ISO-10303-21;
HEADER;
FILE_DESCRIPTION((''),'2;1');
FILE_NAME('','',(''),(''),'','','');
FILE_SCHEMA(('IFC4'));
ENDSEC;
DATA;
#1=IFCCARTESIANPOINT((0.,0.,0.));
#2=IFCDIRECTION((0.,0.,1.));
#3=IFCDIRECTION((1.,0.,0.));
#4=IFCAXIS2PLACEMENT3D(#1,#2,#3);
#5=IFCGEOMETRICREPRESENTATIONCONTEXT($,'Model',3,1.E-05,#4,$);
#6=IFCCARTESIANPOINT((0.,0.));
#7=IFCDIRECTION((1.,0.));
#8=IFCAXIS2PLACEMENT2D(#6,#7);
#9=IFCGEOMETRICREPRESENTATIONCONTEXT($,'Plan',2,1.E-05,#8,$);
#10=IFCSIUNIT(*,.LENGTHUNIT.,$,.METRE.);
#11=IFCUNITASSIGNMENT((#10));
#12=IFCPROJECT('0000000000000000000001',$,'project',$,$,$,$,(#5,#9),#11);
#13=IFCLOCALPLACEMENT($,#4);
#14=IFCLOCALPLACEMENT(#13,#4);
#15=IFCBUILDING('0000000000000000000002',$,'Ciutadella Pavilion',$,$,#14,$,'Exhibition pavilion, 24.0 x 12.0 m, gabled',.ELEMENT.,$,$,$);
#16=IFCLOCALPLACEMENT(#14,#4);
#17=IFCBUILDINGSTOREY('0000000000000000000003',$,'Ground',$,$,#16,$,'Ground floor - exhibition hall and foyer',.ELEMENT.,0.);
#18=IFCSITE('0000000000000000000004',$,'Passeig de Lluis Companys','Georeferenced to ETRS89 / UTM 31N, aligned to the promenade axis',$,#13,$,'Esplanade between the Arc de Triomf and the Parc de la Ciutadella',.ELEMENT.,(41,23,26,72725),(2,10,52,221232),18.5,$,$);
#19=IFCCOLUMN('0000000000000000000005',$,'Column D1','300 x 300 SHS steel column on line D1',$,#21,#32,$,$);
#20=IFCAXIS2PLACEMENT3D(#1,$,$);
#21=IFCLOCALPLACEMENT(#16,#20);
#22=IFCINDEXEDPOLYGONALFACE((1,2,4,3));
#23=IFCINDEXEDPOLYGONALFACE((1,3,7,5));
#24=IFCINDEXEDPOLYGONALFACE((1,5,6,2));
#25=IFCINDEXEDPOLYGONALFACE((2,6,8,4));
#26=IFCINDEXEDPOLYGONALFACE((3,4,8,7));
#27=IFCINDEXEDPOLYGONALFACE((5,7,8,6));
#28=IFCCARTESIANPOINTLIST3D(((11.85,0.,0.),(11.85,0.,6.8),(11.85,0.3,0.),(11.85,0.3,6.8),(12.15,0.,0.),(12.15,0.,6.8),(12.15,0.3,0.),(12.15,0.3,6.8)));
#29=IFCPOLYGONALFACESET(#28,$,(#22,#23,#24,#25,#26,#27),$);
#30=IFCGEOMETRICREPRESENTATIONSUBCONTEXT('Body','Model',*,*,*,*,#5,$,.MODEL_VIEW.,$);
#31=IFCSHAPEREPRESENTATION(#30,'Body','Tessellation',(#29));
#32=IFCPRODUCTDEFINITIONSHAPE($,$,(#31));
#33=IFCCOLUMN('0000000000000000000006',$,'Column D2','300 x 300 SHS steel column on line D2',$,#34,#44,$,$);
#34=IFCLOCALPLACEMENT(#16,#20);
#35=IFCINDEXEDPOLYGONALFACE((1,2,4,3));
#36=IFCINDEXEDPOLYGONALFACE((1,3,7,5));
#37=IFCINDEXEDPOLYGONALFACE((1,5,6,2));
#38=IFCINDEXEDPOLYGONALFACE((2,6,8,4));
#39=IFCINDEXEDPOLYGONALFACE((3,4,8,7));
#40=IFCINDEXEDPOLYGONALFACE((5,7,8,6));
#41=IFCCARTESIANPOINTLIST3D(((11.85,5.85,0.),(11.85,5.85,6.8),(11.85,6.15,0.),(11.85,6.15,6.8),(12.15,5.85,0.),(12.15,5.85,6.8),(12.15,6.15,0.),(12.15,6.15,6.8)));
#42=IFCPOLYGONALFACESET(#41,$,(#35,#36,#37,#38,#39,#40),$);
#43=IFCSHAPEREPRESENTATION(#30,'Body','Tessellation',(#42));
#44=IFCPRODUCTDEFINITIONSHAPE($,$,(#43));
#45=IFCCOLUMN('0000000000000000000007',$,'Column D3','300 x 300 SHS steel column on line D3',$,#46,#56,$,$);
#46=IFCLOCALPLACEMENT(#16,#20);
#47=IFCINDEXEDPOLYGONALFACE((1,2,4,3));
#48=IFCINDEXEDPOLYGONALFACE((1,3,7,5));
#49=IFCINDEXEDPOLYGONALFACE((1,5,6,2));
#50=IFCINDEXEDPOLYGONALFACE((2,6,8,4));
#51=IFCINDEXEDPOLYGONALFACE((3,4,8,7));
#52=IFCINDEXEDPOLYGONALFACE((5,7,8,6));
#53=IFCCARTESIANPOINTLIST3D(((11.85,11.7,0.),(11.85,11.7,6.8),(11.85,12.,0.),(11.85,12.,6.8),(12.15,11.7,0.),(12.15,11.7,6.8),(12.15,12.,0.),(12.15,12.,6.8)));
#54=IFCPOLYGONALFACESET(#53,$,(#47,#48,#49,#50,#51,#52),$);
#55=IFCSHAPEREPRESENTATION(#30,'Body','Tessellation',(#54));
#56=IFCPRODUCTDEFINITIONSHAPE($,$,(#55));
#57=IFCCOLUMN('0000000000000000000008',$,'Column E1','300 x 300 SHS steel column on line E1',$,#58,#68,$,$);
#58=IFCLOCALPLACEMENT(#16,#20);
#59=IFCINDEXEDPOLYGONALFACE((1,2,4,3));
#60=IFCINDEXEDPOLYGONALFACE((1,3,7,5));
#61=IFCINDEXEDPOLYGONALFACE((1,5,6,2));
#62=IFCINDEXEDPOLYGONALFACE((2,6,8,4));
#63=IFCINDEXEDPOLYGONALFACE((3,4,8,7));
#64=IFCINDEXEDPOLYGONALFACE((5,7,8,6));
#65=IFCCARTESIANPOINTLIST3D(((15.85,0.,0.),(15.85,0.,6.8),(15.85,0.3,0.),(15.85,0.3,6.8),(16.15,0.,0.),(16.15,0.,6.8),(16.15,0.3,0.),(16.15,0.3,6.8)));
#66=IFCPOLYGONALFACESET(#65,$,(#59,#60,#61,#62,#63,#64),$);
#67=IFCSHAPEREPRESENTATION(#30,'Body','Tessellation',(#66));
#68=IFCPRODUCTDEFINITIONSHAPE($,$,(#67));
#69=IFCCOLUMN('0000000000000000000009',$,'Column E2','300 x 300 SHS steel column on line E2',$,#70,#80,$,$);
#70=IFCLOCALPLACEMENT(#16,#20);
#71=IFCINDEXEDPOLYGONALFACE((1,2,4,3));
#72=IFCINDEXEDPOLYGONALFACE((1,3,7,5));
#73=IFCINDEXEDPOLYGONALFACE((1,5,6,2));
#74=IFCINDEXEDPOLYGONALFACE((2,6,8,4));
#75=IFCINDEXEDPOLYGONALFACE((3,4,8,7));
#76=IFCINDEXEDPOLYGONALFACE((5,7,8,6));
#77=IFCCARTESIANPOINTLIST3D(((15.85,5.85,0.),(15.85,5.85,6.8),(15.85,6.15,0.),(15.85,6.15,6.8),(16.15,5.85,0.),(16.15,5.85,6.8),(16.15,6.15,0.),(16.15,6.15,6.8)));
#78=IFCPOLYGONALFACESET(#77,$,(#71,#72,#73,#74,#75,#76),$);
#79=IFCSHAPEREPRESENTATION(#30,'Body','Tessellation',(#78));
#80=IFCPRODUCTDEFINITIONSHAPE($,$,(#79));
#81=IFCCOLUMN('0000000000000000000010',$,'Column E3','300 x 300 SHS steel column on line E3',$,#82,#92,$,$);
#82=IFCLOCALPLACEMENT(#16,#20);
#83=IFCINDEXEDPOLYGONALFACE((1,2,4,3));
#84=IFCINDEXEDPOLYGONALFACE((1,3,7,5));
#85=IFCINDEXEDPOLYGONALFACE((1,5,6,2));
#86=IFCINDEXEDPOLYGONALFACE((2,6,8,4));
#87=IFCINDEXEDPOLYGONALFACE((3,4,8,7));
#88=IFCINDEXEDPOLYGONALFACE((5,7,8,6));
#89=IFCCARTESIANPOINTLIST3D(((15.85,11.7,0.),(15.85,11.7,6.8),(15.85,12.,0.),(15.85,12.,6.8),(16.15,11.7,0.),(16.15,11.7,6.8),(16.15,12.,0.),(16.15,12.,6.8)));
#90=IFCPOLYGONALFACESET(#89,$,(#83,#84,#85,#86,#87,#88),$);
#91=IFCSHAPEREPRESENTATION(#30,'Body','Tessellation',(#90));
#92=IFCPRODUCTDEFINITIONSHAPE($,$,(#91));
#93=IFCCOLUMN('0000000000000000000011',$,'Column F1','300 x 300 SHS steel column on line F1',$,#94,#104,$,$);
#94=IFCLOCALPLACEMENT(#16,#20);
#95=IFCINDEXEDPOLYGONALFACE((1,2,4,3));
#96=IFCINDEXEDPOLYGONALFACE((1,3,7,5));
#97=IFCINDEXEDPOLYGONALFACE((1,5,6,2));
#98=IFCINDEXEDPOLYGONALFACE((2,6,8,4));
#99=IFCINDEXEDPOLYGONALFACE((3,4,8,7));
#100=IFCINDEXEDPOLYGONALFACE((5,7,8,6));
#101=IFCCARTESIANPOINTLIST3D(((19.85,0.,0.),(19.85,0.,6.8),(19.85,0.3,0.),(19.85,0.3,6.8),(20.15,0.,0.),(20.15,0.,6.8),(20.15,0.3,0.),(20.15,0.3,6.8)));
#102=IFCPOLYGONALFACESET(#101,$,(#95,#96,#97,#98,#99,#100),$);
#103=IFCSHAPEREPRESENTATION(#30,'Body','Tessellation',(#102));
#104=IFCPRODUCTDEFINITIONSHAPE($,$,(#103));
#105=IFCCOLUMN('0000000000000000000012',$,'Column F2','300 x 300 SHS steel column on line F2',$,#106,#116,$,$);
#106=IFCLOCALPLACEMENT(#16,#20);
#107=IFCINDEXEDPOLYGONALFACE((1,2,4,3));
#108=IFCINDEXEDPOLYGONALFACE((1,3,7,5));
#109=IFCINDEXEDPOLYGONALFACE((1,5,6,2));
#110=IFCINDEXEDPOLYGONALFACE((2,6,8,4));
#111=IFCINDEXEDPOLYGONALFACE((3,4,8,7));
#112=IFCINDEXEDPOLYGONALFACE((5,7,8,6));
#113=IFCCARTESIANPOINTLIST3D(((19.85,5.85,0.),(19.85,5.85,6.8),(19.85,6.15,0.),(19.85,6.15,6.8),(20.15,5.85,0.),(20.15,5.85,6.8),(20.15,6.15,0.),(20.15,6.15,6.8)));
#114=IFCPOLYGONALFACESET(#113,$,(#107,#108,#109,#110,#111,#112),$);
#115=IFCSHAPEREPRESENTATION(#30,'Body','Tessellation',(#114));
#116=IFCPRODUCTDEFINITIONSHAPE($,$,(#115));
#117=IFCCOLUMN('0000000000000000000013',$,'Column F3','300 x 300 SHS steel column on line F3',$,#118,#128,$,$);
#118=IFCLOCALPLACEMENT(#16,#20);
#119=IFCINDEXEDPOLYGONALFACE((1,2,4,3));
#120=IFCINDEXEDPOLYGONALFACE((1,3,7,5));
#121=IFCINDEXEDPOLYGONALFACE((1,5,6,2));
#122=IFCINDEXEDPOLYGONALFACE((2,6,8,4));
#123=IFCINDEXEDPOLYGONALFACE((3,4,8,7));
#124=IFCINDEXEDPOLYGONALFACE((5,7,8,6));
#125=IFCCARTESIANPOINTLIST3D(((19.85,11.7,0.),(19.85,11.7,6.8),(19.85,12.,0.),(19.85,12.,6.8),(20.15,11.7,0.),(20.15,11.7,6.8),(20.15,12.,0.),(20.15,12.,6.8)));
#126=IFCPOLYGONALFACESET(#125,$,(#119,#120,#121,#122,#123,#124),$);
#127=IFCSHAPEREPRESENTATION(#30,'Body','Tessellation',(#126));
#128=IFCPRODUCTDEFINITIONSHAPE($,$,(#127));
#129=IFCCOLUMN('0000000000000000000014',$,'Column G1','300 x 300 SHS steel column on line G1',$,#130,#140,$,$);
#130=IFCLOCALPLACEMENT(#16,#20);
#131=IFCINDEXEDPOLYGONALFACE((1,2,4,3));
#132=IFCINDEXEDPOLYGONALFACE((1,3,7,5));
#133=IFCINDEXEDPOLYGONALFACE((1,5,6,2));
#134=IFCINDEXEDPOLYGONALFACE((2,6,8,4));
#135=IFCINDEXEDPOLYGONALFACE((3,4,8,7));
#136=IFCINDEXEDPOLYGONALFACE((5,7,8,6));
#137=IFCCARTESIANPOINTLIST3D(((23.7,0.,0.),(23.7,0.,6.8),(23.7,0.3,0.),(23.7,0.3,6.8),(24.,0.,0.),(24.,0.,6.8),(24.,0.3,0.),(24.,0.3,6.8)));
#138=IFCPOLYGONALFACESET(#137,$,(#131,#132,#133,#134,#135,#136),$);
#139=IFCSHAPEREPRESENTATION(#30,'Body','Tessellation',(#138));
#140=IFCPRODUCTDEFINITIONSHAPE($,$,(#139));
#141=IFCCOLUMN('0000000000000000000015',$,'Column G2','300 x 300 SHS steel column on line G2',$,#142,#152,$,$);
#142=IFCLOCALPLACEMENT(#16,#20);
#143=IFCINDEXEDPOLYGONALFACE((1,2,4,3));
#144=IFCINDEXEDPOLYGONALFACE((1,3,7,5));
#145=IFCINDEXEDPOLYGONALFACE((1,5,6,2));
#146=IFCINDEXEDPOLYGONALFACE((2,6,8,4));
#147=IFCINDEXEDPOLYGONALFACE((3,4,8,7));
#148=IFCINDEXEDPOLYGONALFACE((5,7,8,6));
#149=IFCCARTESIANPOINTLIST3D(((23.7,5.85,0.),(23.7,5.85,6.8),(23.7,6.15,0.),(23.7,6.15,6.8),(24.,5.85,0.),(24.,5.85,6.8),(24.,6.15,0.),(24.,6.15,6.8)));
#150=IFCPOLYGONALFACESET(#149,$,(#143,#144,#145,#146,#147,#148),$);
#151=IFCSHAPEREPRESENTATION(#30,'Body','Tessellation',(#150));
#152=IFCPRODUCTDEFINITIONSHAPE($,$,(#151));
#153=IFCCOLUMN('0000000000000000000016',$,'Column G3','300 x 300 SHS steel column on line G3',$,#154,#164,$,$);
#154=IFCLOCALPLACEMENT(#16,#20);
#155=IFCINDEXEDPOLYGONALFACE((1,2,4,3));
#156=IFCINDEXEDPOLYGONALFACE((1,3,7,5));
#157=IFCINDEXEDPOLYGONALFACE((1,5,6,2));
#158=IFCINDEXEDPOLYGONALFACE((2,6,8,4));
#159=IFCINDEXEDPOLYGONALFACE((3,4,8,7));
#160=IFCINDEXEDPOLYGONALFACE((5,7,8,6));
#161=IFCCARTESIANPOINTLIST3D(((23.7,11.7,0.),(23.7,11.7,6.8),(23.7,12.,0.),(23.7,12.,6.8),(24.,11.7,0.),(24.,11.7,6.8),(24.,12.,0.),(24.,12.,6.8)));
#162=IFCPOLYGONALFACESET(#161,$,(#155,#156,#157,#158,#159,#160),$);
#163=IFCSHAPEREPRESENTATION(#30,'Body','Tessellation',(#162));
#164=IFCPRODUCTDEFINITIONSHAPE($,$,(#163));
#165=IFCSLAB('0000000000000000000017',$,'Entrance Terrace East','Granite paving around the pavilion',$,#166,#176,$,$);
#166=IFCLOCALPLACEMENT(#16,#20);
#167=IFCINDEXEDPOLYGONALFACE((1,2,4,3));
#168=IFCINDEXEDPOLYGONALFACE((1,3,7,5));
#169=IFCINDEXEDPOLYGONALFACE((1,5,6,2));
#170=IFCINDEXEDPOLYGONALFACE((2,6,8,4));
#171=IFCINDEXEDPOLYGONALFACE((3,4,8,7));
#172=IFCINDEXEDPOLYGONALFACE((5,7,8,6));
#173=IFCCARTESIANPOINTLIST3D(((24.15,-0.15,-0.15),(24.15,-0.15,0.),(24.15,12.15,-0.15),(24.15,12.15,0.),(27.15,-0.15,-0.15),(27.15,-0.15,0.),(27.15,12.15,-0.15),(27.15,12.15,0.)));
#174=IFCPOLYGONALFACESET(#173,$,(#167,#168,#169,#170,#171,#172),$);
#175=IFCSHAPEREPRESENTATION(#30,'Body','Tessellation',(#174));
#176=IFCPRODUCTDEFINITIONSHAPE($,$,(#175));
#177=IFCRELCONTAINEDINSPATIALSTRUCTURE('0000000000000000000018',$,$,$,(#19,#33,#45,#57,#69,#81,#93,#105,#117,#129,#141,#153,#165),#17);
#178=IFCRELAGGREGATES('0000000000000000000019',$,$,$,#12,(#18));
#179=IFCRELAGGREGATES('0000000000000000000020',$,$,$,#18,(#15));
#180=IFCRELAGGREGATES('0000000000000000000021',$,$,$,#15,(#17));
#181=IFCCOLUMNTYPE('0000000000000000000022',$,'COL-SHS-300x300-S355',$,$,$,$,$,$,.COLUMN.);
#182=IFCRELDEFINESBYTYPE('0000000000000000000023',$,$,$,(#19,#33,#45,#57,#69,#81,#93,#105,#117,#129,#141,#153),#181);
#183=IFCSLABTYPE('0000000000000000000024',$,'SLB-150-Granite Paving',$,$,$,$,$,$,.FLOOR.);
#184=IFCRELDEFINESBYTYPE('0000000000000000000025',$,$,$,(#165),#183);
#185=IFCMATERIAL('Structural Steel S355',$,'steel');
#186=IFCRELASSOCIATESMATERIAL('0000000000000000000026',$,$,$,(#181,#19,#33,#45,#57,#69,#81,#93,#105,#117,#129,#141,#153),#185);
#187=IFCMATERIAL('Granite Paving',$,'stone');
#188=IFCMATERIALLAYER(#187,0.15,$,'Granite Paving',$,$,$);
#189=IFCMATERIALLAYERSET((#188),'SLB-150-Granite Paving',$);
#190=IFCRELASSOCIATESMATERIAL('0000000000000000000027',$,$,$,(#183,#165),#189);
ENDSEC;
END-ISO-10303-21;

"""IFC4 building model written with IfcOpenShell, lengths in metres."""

from ifc_helpers import new_model, si_unit, frame, origin_with_axes, origin_2d_with_axis, place, context, subcontext, project, spatial, line, indexed_curve, rectangle, outline, extrude, material, layer, layer_set, layer_usage, material_profile, profile_set, profile_usage, type_object, element, save


model = new_model("IFC4")

# Units and contexts
model_context = context("Model", 3, precision=1e-05, world=origin_with_axes())
plan_context = context("Plan", 2, precision=1e-05, world=origin_2d_with_axis())
body_context = subcontext(model_context, "Body", "Model", "MODEL_VIEW")
ifc_project = project(units=[si_unit("LENGTHUNIT", "METRE")], contexts=[model_context, plan_context])

# Site, building, storey
site_placement = place(None, origin_with_axes())
site = spatial("IfcSite", under=ifc_project, at=site_placement, Name="Passeig de Lluis Companys", Description="Georeferenced to ETRS89 / UTM 31N, aligned to the promenade axis", LongName="Esplanade between the Arc de Triomf and the Parc de la Ciutadella", CompositionType="ELEMENT", RefLatitude=(41, 23, 26, 72725), RefLongitude=(2, 10, 52, 221232), RefElevation=18.5)
building_placement = place(site_placement, origin_with_axes())
building = spatial("IfcBuilding", under=site, at=building_placement, Name="Ciutadella Pavilion", LongName="Exhibition pavilion, 24.0 x 12.0 m, gabled", CompositionType="ELEMENT")
storey_placement = place(building_placement, origin_with_axes())
storey = spatial("IfcBuildingStorey", under=building, at=storey_placement, Name="Ground", LongName="Ground floor - exhibition hall and foyer", CompositionType="ELEMENT", Elevation=0.0)

# Columns
ifc_material_1 = material(Name="Structural Steel S355", Category="steel")
ifc_material_profile = material_profile(ifc_material_1, rectangle(XDim=0.3, YDim=0.3))
ifc_profile_set = profile_set([ifc_material_profile], Name="COL-SHS-300x300-S355")
ifc_profile_usage_1 = profile_usage(ifc_profile_set)
column_type = type_object("IfcColumnType", Name="COL-SHS-300x300-S355", PredefinedType="COLUMN", material=ifc_profile_set)
column_1_placement = place(storey_placement, frame((11.85, 0.0, 0.0), z_axis=(0.0, 0.0, 1.0), x_axis=(1.0, 0.0, 0.0)))
element("IfcColumn", 1, at=column_1_placement, inside=storey, type_object=column_type, material=ifc_profile_usage_1, Name="Column D1", Description="300 x 300 SHS steel column on line D1", context=body_context, shape_type="SweptSolid", body=[
    extrude(outline(indexed_curve([(0.0, 0.0), (0.3, 0.0), (0.3, 0.3), (0.0, 0.3)], segments=[line(1, 2, 3, 4, 1)])), origin_with_axes(), (0.0, 0.0, 1.0), 6.8),
])
ifc_profile_usage_2 = profile_usage(ifc_profile_set)
column_2_placement = place(storey_placement, frame((11.85, 5.85, 0.0), z_axis=(0.0, 0.0, 1.0), x_axis=(1.0, 0.0, 0.0)))
element("IfcColumn", 2, at=column_2_placement, inside=storey, type_object=column_type, material=ifc_profile_usage_2, Name="Column D2", Description="300 x 300 SHS steel column on line D2", context=body_context, shape_type="SweptSolid", body=[
    extrude(outline(indexed_curve([(0.0, 0.0), (0.3, 0.0), (0.3, 0.3), (0.0, 0.3)], segments=[line(1, 2, 3, 4, 1)])), origin_with_axes(), (0.0, 0.0, 1.0), 6.8),
])
ifc_profile_usage_3 = profile_usage(ifc_profile_set)
column_3_placement = place(storey_placement, frame((11.85, 11.7, 0.0), z_axis=(0.0, 0.0, 1.0), x_axis=(1.0, 0.0, 0.0)))
element("IfcColumn", 3, at=column_3_placement, inside=storey, type_object=column_type, material=ifc_profile_usage_3, Name="Column D3", Description="300 x 300 SHS steel column on line D3", context=body_context, shape_type="SweptSolid", body=[
    extrude(outline(indexed_curve([(0.0, 0.0), (0.3, 0.0), (0.3, 0.3), (0.0, 0.3)], segments=[line(1, 2, 3, 4, 1)])), origin_with_axes(), (0.0, 0.0, 1.0), 6.8),
])
ifc_profile_usage_4 = profile_usage(ifc_profile_set)
column_4_placement = place(storey_placement, frame((15.85, 0.0, 0.0), z_axis=(0.0, 0.0, 1.0), x_axis=(1.0, 0.0, 0.0)))
element("IfcColumn", 4, at=column_4_placement, inside=storey, type_object=column_type, material=ifc_profile_usage_4, Name="Column E1", Description="300 x 300 SHS steel column on line E1", context=body_context, shape_type="SweptSolid", body=[
    extrude(outline(indexed_curve([(0.0, 0.0), (0.3, 0.0), (0.3, 0.3), (0.0, 0.3)], segments=[line(1, 2, 3, 4, 1)])), origin_with_axes(), (0.0, 0.0, 1.0), 6.8),
])
ifc_profile_usage_5 = profile_usage(ifc_profile_set)
column_5_placement = place(storey_placement, frame((15.85, 5.85, 0.0), z_axis=(0.0, 0.0, 1.0), x_axis=(1.0, 0.0, 0.0)))
element("IfcColumn", 5, at=column_5_placement, inside=storey, type_object=column_type, material=ifc_profile_usage_5, Name="Column E2", Description="300 x 300 SHS steel column on line E2", context=body_context, shape_type="SweptSolid", body=[
    extrude(outline(indexed_curve([(0.0, 0.0), (0.3, 0.0), (0.3, 0.3), (0.0, 0.3)], segments=[line(1, 2, 3, 4, 1)])), origin_with_axes(), (0.0, 0.0, 1.0), 6.8),
])
ifc_profile_usage_6 = profile_usage(ifc_profile_set)
column_6_placement = place(storey_placement, frame((15.85, 11.7, 0.0), z_axis=(0.0, 0.0, 1.0), x_axis=(1.0, 0.0, 0.0)))
element("IfcColumn", 6, at=column_6_placement, inside=storey, type_object=column_type, material=ifc_profile_usage_6, Name="Column E3", Description="300 x 300 SHS steel column on line E3", context=body_context, shape_type="SweptSolid", body=[
    extrude(outline(indexed_curve([(0.0, 0.0), (0.3, 0.0), (0.3, 0.3), (0.0, 0.3)], segments=[line(1, 2, 3, 4, 1)])), origin_with_axes(), (0.0, 0.0, 1.0), 6.8),
])
ifc_profile_usage_7 = profile_usage(ifc_profile_set)
column_7_placement = place(storey_placement, frame((19.85, 0.0, 0.0), z_axis=(0.0, 0.0, 1.0), x_axis=(1.0, 0.0, 0.0)))
element("IfcColumn", 7, at=column_7_placement, inside=storey, type_object=column_type, material=ifc_profile_usage_7, Name="Column F1", Description="300 x 300 SHS steel column on line F1", context=body_context, shape_type="SweptSolid", body=[
    extrude(outline(indexed_curve([(0.0, 0.0), (0.3, 0.0), (0.3, 0.3), (0.0, 0.3)], segments=[line(1, 2, 3, 4, 1)])), origin_with_axes(), (0.0, 0.0, 1.0), 6.8),
])
ifc_profile_usage_8 = profile_usage(ifc_profile_set)
column_8_placement = place(storey_placement, frame((19.85, 5.85, 0.0), z_axis=(0.0, 0.0, 1.0), x_axis=(1.0, 0.0, 0.0)))
element("IfcColumn", 8, at=column_8_placement, inside=storey, type_object=column_type, material=ifc_profile_usage_8, Name="Column F2", Description="300 x 300 SHS steel column on line F2", context=body_context, shape_type="SweptSolid", body=[
    extrude(outline(indexed_curve([(0.0, 0.0), (0.3, 0.0), (0.3, 0.3), (0.0, 0.3)], segments=[line(1, 2, 3, 4, 1)])), origin_with_axes(), (0.0, 0.0, 1.0), 6.8),
])
ifc_profile_usage_9 = profile_usage(ifc_profile_set)
column_9_placement = place(storey_placement, frame((19.85, 11.7, 0.0), z_axis=(0.0, 0.0, 1.0), x_axis=(1.0, 0.0, 0.0)))
element("IfcColumn", 9, at=column_9_placement, inside=storey, type_object=column_type, material=ifc_profile_usage_9, Name="Column F3", Description="300 x 300 SHS steel column on line F3", context=body_context, shape_type="SweptSolid", body=[
    extrude(outline(indexed_curve([(0.0, 0.0), (0.3, 0.0), (0.3, 0.3), (0.0, 0.3)], segments=[line(1, 2, 3, 4, 1)])), origin_with_axes(), (0.0, 0.0, 1.0), 6.8),
])
ifc_profile_usage_10 = profile_usage(ifc_profile_set)
column_10_placement = place(storey_placement, frame((23.7, 0.0, 0.0), z_axis=(0.0, 0.0, 1.0), x_axis=(1.0, 0.0, 0.0)))
element("IfcColumn", 10, at=column_10_placement, inside=storey, type_object=column_type, material=ifc_profile_usage_10, Name="Column G1", Description="300 x 300 SHS steel column on line G1", context=body_context, shape_type="SweptSolid", body=[
    extrude(outline(indexed_curve([(0.0, 0.0), (0.3, 0.0), (0.3, 0.3), (0.0, 0.3)], segments=[line(1, 2, 3, 4, 1)])), origin_with_axes(), (0.0, 0.0, 1.0), 6.8),
])
ifc_profile_usage_11 = profile_usage(ifc_profile_set)
column_11_placement = place(storey_placement, frame((23.7, 5.85, 0.0), z_axis=(0.0, 0.0, 1.0), x_axis=(1.0, 0.0, 0.0)))
element("IfcColumn", 11, at=column_11_placement, inside=storey, type_object=column_type, material=ifc_profile_usage_11, Name="Column G2", Description="300 x 300 SHS steel column on line G2", context=body_context, shape_type="SweptSolid", body=[
    extrude(outline(indexed_curve([(0.0, 0.0), (0.3, 0.0), (0.3, 0.3), (0.0, 0.3)], segments=[line(1, 2, 3, 4, 1)])), origin_with_axes(), (0.0, 0.0, 1.0), 6.8),
])
ifc_profile_usage_12 = profile_usage(ifc_profile_set)
column_12_placement = place(storey_placement, frame((23.7, 11.7, 0.0), z_axis=(0.0, 0.0, 1.0), x_axis=(1.0, 0.0, 0.0)))
element("IfcColumn", 12, at=column_12_placement, inside=storey, type_object=column_type, material=ifc_profile_usage_12, Name="Column G3", Description="300 x 300 SHS steel column on line G3", context=body_context, shape_type="SweptSolid", body=[
    extrude(outline(indexed_curve([(0.0, 0.0), (0.3, 0.0), (0.3, 0.3), (0.0, 0.3)], segments=[line(1, 2, 3, 4, 1)])), origin_with_axes(), (0.0, 0.0, 1.0), 6.8),
])

# Slab
ifc_material_2 = material(Name="Granite Paving", Category="stone")
ifc_layer_1 = layer(ifc_material_2, 0.15, Name="Granite Paving")
ifc_layer_set_1 = layer_set([ifc_layer_1], Name="SLB-150-Granite Paving")
ifc_layer_usage_1 = layer_usage(ifc_layer_set_1, "AXIS3", "POSITIVE", 0.0)
slab_type = type_object("IfcSlabType", Name="SLB-150-Granite Paving", PredefinedType="FLOOR", material=ifc_layer_set_1)
slab_placement = place(storey_placement, frame((24.15, -0.15, -0.15), z_axis=(0.0, 0.0, 1.0), x_axis=(1.0, 0.0, 0.0)))
element("IfcSlab", 13, at=slab_placement, inside=storey, type_object=slab_type, material=ifc_layer_usage_1, Name="Entrance Terrace East", Description="Granite paving around the pavilion", context=body_context, shape_type="SweptSolid", body=[
    extrude(outline(indexed_curve([(0.0, 0.0), (3.0, 0.0), (3.0, 12.3), (0.0, 12.3)], segments=[line(1, 2, 3, 4, 1)])), origin_with_axes(), (0.0, 0.0, 1.0), 0.15),
])

save(model, "model.ifc")
